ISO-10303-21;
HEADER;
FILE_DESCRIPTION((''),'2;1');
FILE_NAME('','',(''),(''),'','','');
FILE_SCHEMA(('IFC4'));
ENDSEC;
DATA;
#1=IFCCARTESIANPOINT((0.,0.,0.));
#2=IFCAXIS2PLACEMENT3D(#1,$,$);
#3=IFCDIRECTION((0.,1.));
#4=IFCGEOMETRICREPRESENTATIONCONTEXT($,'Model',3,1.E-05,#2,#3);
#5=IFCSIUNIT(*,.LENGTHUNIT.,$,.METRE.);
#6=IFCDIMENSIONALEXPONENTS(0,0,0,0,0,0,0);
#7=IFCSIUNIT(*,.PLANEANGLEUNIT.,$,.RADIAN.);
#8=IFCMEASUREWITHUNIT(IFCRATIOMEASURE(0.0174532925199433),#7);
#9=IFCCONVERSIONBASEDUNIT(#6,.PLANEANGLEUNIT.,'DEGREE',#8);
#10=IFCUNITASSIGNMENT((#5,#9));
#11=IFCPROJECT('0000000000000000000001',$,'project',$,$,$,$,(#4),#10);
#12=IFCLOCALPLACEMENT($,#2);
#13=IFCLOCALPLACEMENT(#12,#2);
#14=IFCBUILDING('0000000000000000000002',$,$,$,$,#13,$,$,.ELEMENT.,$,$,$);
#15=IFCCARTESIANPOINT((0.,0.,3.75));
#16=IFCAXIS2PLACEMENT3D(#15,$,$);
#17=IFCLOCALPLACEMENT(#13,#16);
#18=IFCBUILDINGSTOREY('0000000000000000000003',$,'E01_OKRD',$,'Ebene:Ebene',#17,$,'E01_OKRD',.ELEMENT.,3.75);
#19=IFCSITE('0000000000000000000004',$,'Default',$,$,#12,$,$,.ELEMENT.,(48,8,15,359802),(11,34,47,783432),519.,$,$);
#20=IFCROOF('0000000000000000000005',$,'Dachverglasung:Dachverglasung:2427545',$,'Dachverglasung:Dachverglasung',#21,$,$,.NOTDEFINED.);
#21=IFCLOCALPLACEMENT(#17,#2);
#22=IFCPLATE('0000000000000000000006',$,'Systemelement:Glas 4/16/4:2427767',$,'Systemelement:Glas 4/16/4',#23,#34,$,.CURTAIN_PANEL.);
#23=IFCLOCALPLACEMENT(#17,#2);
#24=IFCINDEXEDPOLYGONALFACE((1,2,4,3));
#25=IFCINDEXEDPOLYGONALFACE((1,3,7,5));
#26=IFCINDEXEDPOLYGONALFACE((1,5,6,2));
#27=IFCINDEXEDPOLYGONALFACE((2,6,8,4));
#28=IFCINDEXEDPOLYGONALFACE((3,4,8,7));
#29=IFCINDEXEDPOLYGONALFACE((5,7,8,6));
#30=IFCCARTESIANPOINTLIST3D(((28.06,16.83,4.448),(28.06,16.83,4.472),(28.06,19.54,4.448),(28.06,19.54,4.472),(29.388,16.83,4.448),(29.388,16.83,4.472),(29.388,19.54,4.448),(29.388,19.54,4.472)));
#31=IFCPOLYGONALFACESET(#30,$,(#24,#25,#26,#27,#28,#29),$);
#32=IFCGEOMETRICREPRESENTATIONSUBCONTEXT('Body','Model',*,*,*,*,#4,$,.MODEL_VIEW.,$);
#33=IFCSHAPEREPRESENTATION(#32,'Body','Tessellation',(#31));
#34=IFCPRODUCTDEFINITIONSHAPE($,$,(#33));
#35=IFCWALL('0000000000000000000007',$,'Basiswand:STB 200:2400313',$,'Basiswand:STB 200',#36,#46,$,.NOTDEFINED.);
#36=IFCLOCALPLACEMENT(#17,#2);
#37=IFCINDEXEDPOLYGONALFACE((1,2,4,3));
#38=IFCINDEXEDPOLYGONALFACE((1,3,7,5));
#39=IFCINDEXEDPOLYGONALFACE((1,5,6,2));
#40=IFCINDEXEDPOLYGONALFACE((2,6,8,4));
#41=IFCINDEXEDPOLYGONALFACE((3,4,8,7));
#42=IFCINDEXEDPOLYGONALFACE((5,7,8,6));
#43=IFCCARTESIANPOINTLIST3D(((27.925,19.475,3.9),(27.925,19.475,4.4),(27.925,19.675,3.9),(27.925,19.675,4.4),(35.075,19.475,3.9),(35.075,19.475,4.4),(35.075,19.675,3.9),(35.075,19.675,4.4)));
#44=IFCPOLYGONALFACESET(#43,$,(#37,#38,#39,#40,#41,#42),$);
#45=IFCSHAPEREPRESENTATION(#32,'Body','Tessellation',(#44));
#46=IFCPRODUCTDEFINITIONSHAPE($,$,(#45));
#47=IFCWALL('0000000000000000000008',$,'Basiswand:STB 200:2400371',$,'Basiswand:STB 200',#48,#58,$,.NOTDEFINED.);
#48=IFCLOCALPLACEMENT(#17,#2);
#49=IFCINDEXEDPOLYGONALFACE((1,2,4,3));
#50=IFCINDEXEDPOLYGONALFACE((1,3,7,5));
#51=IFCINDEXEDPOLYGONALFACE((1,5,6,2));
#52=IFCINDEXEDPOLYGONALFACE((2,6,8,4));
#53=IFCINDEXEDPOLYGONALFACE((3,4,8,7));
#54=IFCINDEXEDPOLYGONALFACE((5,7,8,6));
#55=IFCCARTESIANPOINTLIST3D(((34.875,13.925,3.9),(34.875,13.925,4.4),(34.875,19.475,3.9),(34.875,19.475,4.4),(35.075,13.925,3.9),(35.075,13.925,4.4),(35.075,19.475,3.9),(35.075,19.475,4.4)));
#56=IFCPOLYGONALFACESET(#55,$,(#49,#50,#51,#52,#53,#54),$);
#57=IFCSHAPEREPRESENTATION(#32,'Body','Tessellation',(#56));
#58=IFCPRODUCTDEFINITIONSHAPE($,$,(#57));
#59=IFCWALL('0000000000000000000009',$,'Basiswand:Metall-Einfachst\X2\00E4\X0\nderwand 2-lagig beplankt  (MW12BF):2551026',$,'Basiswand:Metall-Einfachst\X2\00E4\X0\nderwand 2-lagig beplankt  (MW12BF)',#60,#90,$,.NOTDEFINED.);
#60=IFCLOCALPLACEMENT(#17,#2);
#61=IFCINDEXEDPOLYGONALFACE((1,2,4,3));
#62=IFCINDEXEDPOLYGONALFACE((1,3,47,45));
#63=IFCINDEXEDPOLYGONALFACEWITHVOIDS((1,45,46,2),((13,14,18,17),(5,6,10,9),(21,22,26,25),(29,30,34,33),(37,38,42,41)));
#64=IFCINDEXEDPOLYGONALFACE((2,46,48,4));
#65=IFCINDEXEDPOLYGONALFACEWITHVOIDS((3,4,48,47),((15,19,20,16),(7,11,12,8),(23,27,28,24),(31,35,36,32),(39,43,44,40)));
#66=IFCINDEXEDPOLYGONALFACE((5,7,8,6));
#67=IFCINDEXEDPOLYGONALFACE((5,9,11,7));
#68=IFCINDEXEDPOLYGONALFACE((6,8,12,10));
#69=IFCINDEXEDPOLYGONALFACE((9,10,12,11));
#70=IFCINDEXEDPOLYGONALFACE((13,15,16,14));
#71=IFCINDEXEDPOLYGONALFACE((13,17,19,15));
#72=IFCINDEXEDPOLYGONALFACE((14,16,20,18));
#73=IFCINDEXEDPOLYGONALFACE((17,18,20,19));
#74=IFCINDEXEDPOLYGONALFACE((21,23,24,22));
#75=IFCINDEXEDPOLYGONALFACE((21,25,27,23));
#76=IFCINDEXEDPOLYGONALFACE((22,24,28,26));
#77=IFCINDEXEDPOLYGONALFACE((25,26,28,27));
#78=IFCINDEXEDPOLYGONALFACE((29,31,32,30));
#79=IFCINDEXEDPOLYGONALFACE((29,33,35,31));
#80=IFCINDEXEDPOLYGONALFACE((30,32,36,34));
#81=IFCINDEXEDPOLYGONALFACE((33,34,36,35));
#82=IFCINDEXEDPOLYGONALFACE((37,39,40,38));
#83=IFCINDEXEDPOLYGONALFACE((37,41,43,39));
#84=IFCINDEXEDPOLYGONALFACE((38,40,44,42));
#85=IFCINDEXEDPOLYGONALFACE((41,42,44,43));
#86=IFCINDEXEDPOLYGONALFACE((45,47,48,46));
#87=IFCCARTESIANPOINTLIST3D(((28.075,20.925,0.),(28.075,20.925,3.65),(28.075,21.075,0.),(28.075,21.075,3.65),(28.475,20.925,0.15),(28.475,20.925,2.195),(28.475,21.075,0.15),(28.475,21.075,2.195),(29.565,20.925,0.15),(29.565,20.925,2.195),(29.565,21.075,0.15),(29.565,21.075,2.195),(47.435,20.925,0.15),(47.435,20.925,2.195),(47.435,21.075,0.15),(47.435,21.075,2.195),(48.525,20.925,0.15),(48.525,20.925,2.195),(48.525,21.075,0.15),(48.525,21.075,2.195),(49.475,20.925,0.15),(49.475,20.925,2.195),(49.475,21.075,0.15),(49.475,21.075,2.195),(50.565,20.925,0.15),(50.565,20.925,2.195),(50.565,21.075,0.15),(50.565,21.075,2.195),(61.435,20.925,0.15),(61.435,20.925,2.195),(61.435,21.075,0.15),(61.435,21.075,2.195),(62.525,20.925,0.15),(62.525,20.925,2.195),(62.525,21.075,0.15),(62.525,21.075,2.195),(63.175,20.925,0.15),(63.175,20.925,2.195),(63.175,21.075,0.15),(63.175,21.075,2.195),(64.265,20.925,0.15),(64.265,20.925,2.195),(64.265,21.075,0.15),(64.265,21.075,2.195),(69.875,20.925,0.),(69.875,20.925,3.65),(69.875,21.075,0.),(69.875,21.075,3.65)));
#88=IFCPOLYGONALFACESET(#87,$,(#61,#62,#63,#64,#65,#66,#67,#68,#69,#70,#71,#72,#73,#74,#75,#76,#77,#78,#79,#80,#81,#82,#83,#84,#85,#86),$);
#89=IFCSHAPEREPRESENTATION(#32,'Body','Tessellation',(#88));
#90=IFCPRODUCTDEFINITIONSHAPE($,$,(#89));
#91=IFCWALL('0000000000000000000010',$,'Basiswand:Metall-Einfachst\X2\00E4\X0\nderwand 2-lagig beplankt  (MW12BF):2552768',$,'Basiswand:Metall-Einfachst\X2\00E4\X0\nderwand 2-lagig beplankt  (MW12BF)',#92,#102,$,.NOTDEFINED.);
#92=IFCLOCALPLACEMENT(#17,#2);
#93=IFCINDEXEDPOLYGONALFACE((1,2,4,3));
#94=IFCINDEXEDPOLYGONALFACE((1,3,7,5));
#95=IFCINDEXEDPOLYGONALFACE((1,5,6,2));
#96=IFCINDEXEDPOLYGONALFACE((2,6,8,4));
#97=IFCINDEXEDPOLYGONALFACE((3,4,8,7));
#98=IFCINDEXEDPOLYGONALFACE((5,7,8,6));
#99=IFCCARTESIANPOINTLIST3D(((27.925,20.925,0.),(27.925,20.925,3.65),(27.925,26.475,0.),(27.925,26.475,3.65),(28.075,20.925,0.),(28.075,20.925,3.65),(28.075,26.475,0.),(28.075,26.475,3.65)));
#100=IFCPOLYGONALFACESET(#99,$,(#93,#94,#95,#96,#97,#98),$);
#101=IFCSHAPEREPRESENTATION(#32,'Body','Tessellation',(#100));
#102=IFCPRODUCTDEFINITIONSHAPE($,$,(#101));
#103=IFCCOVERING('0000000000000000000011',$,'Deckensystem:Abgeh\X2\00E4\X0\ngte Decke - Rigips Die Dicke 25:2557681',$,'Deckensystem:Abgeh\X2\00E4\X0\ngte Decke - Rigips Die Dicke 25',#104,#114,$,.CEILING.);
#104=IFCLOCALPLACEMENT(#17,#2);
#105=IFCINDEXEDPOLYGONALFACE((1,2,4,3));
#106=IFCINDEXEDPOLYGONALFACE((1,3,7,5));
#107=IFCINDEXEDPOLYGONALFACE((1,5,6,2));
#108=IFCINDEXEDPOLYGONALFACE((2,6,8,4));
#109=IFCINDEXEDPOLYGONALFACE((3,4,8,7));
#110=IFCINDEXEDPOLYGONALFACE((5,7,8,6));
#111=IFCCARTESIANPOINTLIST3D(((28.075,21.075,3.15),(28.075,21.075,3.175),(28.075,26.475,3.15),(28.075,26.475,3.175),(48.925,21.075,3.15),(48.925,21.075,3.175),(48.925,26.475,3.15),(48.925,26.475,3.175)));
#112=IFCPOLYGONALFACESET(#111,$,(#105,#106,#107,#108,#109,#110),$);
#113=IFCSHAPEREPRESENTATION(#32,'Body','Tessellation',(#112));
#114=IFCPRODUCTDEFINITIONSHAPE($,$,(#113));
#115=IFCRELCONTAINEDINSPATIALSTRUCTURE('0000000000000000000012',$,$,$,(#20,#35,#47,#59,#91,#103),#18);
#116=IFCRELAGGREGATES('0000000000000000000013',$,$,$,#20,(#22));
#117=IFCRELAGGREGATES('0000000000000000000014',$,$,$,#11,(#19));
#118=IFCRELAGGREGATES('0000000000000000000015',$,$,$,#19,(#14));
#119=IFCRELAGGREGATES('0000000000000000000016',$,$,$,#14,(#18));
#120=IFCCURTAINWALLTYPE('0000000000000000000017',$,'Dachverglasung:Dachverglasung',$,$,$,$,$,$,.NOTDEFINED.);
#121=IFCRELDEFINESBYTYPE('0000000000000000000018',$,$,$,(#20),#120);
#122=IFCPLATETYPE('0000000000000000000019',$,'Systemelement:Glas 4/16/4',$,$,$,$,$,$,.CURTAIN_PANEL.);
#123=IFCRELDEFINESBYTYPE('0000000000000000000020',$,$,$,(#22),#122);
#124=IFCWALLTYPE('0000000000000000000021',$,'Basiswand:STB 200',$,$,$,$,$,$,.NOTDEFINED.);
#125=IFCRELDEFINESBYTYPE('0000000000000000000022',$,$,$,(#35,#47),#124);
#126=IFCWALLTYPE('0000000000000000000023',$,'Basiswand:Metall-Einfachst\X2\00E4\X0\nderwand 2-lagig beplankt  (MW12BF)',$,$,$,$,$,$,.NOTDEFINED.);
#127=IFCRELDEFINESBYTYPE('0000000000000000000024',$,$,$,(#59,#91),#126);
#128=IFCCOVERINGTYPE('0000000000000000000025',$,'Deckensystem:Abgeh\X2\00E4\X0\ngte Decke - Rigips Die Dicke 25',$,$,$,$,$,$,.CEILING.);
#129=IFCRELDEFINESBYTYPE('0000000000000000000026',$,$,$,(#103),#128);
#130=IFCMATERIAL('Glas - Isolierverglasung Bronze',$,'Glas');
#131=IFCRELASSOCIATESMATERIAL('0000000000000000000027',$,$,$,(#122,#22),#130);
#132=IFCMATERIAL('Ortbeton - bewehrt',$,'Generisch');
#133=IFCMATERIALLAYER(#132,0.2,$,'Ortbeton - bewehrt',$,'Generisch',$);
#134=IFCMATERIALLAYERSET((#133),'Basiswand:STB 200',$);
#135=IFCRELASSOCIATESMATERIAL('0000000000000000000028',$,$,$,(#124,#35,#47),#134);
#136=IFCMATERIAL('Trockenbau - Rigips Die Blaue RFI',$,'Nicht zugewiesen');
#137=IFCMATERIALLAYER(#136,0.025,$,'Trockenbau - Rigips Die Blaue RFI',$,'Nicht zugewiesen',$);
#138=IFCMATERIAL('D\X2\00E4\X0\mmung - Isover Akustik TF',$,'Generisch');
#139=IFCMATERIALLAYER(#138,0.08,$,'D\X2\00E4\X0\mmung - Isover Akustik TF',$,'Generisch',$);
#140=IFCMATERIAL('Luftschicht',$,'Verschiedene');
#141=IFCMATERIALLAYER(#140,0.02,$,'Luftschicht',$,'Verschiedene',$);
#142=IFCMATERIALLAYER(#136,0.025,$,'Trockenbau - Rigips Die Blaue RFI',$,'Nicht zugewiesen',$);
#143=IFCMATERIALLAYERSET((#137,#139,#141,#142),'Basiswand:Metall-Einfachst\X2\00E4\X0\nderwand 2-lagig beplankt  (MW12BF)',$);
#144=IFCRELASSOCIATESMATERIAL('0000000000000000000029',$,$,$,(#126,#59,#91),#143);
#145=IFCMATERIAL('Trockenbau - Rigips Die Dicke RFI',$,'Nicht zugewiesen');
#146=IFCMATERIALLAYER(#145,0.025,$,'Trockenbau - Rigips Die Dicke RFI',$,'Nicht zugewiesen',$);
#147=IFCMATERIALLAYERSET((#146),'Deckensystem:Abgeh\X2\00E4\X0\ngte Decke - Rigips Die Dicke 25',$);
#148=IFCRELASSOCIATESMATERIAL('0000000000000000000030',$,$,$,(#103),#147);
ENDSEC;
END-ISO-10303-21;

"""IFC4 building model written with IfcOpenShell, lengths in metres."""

from ifc_helpers import new_model, entity, si_unit, converted_unit, direction, frame, frame_2d, origin, origin_2d_with_axis, place, context, subcontext, project, spatial, rectangle, extrude, shape, source, transform, mapped, material, layer, layer_set, layer_usage, type_object, type_shapes, element, aggregate, save


model = new_model("IFC4")

# Units and contexts
model_context = context("Model", 3, precision=1e-05, world=origin(), true_north=direction((0.0, 1.0)))
body_context = subcontext(model_context, "Body", "Model", "MODEL_VIEW")
footprint_context = subcontext(model_context, "FootPrint", "Model", "MODEL_VIEW")
ifc_project = project(units=[si_unit("LENGTHUNIT", "METRE"), converted_unit("PLANEANGLEUNIT", "DEGREE", entity("IfcRatioMeasure", 0.0174532925199433), si_unit("PLANEANGLEUNIT", "RADIAN"), dimensions=[0, 0, 0, 0, 0, 0, 0])], contexts=[model_context])

# Site, building, storey
site_placement = place(None, frame((0.0, 0.0, 0.0)))
site = spatial("IfcSite", under=ifc_project, at=site_placement, Name="Default", CompositionType="ELEMENT", RefLatitude=(48, 8, 15, 359802), RefLongitude=(11, 34, 47, 783432), RefElevation=519.0)
building_placement = place(site_placement, origin())
building = spatial("IfcBuilding", under=site, at=building_placement, CompositionType="ELEMENT")
storey_placement = place(building_placement, frame((0.0, 0.0, 3.75)))
storey = spatial("IfcBuildingStorey", under=building, at=storey_placement, Name="E01_OKRD", ObjectType="Ebene:Ebene", LongName="E01_OKRD", CompositionType="ELEMENT", Elevation=3.75)

# Shared definitions
ifc_material_1 = material(Name="Ortbeton - bewehrt", Category="Generisch")

# Roof, plate
curtain_wall_type = type_object("IfcCurtainWallType", Name="Dachverglasung:Dachverglasung", PredefinedType="NOTDEFINED")
roof_placement = place(storey_placement, frame((0.0, 0.0, -3.75)))
roof = element("IfcRoof", 1, at=roof_placement, inside=storey, type_object=curtain_wall_type, Name="Dachverglasung:Dachverglasung:2427545", ObjectType="Dachverglasung:Dachverglasung", PredefinedType="NOTDEFINED")
ifc_material_2 = material(Name="Glas - Isolierverglasung Bronze", Category="Glas")
plate_type = type_object("IfcPlateType", Name="Systemelement:Glas 4/16/4", PredefinedType="CURTAIN_PANEL", material=ifc_material_2)
shared_shape_1 = source(origin(), body_context, "Body", "SweptSolid", [
    extrude(rectangle(XDim=0.024, YDim=2.71, at=origin_2d_with_axis()), frame((0.0, 0.0, 0.0), z_axis=(0.0, 0.0, 1.0), x_axis=(0.0, 1.0, 0.0)), (0.0, 0.0, 1.0), 1.328),
])
cartesian_point = entity("IfcCartesianPoint", [1.355, -0.012])
shared_shape_2 = source(origin(), footprint_context, "FootPrint", "Curve2D", [
    entity("IfcPolyline", [cartesian_point, entity("IfcCartesianPoint", [1.355, 0.012]), entity("IfcCartesianPoint", [-1.355, 0.012]), entity("IfcCartesianPoint", [-1.355, -0.012]), cartesian_point]),
])
type_shapes(plate_type, [shared_shape_1, shared_shape_2])
plate_1_placement = place(roof_placement, frame((29.388, 18.185, 8.21), z_axis=(-1.0, 0.0, 0.0), x_axis=(0.0, 1.0, 0.0)))
plate_1 = element("IfcPlate", 2, at=plate_1_placement, type_object=plate_type, material=ifc_material_2, Name="Systemelement:Glas 4/16/4:2427767", ObjectType="Systemelement:Glas 4/16/4", PredefinedType="CURTAIN_PANEL", shapes=[
    shape(body_context, "Body", "MappedRepresentation", [mapped(shared_shape_1, transform((0.0, 0.0, 0.0), scale=1.0))]),
    shape(body_context, "Body", "MappedRepresentation", [mapped(shared_shape_2, transform((0.0, 0.0, 0.0), scale=1.0))]),
])
aggregate(roof, [plate_1])

# Walls
ifc_layer_1 = layer(ifc_material_1, 0.2, Name="Ortbeton - bewehrt", Category="Generisch")
ifc_layer_set_1 = layer_set([ifc_layer_1], Name="Basiswand:STB 200")
ifc_layer_usage_1 = layer_usage(ifc_layer_set_1, "AXIS2", "NEGATIVE", 0.1)
wall_type_1 = type_object("IfcWallType", Name="Basiswand:STB 200", PredefinedType="NOTDEFINED", material=ifc_layer_set_1)
wall_1_placement = place(storey_placement, frame((27.925, 19.575, 3.9)))
element("IfcWall", 3, at=wall_1_placement, inside=storey, type_object=wall_type_1, material=ifc_layer_usage_1, Name="Basiswand:STB 200:2400313", ObjectType="Basiswand:STB 200", PredefinedType="NOTDEFINED", context=body_context, shape_type="SweptSolid", body=[
    extrude(rectangle(XDim=7.15, YDim=0.2, at=frame_2d((3.575, 0.0), x_axis=(-1.0, 0.0))), origin(), (0.0, 0.0, 1.0), 0.5),
])
ifc_layer_usage_2 = layer_usage(ifc_layer_set_1, "AXIS2", "NEGATIVE", 0.1)
wall_2_placement = place(storey_placement, frame((34.975, 19.475, 3.9), z_axis=(0.0, 0.0, 1.0), x_axis=(0.0, -1.0, 0.0)))
element("IfcWall", 4, at=wall_2_placement, inside=storey, type_object=wall_type_1, material=ifc_layer_usage_2, Name="Basiswand:STB 200:2400371", ObjectType="Basiswand:STB 200", PredefinedType="NOTDEFINED", context=body_context, shape_type="SweptSolid", body=[
    extrude(rectangle(XDim=5.55, YDim=0.2, at=frame_2d((2.775, 0.0), x_axis=(-1.0, 0.0))), origin(), (0.0, 0.0, 1.0), 0.5),
])

# Wall, openings
ifc_material_3 = material(Name="Trockenbau - Rigips Die Blaue RFI", Category="Nicht zugewiesen")
ifc_layer_2 = layer(ifc_material_3, 0.025, Name="Trockenbau - Rigips Die Blaue RFI", Category="Nicht zugewiesen")
ifc_material_4 = material(Name="Dämmung - Isover Akustik TF", Category="Generisch")
ifc_layer_3 = layer(ifc_material_4, 0.08, Name="Dämmung - Isover Akustik TF", Category="Generisch")
ifc_material_5 = material(Name="Luftschicht", Category="Verschiedene")
ifc_layer_4 = layer(ifc_material_5, 0.02, Name="Luftschicht", Category="Verschiedene")
ifc_layer_5 = layer(ifc_material_3, 0.025, Name="Trockenbau - Rigips Die Blaue RFI", Category="Nicht zugewiesen")
ifc_layer_set_2 = layer_set([ifc_layer_2, ifc_layer_3, ifc_layer_4, ifc_layer_5], Name="Basiswand:Metall-Einfachständerwand 2-lagig beplankt  (MW12BF)")
ifc_layer_usage_3 = layer_usage(ifc_layer_set_2, "AXIS2", "NEGATIVE", 0.075)
wall_type_2 = type_object("IfcWallType", Name="Basiswand:Metall-Einfachständerwand 2-lagig beplankt  (MW12BF)", PredefinedType="NOTDEFINED", material=ifc_layer_set_2)
wall_3_placement = place(storey_placement, frame((28.075, 21.0, 0.0)))
wall_3 = element("IfcWall", 5, at=wall_3_placement, inside=storey, type_object=wall_type_2, material=ifc_layer_usage_3, Name="Basiswand:Metall-Einfachständerwand 2-lagig beplankt  (MW12BF):2551026", ObjectType="Basiswand:Metall-Einfachständerwand 2-lagig beplankt  (MW12BF)", PredefinedType="NOTDEFINED", context=body_context, shape_type="SweptSolid", body=[
    extrude(rectangle(XDim=41.8, YDim=0.15, at=frame_2d((20.9, 0.0), x_axis=(-1.0, 0.0))), origin(), (0.0, 0.0, 1.0), 3.65),
])
opening_1_placement = place(wall_3_placement, frame((0.4, -0.075, 0.15)))
element("IfcOpeningElement", 6, at=opening_1_placement, cuts=wall_3, ObjectType="Opening", PredefinedType="OPENING", context=body_context, shape_type="SweptSolid", body=[
    extrude(rectangle(XDim=2.045, YDim=1.09, at=frame_2d((1.0225, 0.545), x_axis=(-1.0, 0.0))), frame((0.0, 0.0, 0.0), z_axis=(0.0, 1.0, 0.0), x_axis=(0.0, 0.0, 1.0)), (0.0, 0.0, 1.0), 0.15),
])
opening_2_placement = place(wall_3_placement, frame((19.36, -0.075, 0.15)))
element("IfcOpeningElement", 7, at=opening_2_placement, cuts=wall_3, ObjectType="Opening", PredefinedType="OPENING", context=body_context, shape_type="SweptSolid", body=[
    extrude(rectangle(XDim=2.045, YDim=1.09, at=frame_2d((1.0225, 0.545), x_axis=(-1.0, 0.0))), frame((0.0, 0.0, 0.0), z_axis=(0.0, 1.0, 0.0), x_axis=(0.0, 0.0, 1.0)), (0.0, 0.0, 1.0), 0.15),
])
opening_3_placement = place(wall_3_placement, frame((21.4, -0.075, 0.15)))
element("IfcOpeningElement", 8, at=opening_3_placement, cuts=wall_3, ObjectType="Opening", PredefinedType="OPENING", context=body_context, shape_type="SweptSolid", body=[
    extrude(rectangle(XDim=2.045, YDim=1.09, at=frame_2d((1.0225, 0.545), x_axis=(-1.0, 0.0))), frame((0.0, 0.0, 0.0), z_axis=(0.0, 1.0, 0.0), x_axis=(0.0, 0.0, 1.0)), (0.0, 0.0, 1.0), 0.15),
])
opening_4_placement = place(wall_3_placement, frame((33.36, -0.075, 0.15)))
element("IfcOpeningElement", 9, at=opening_4_placement, cuts=wall_3, ObjectType="Opening", PredefinedType="OPENING", context=body_context, shape_type="SweptSolid", body=[
    extrude(rectangle(XDim=2.045, YDim=1.09, at=frame_2d((1.0225, 0.545), x_axis=(-1.0, 0.0))), frame((0.0, 0.0, 0.0), z_axis=(0.0, 1.0, 0.0), x_axis=(0.0, 0.0, 1.0)), (0.0, 0.0, 1.0), 0.15),
])
opening_5_placement = place(wall_3_placement, frame((35.1, -0.075, 0.15)))
element("IfcOpeningElement", 10, at=opening_5_placement, cuts=wall_3, ObjectType="Opening", PredefinedType="OPENING", context=body_context, shape_type="SweptSolid", body=[
    extrude(rectangle(XDim=2.045, YDim=1.09, at=frame_2d((1.0225, 0.545), x_axis=(-1.0, 0.0))), frame((0.0, 0.0, 0.0), z_axis=(0.0, 1.0, 0.0), x_axis=(0.0, 0.0, 1.0)), (0.0, 0.0, 1.0), 0.15),
])

# Wall
ifc_layer_usage_4 = layer_usage(ifc_layer_set_2, "AXIS2", "NEGATIVE", 0.075)
wall_4_placement = place(storey_placement, frame((28.0, 20.925, 0.0), z_axis=(0.0, 0.0, 1.0), x_axis=(0.0, 1.0, 0.0)))
element("IfcWall", 11, at=wall_4_placement, inside=storey, type_object=wall_type_2, material=ifc_layer_usage_4, Name="Basiswand:Metall-Einfachständerwand 2-lagig beplankt  (MW12BF):2552768", ObjectType="Basiswand:Metall-Einfachständerwand 2-lagig beplankt  (MW12BF)", PredefinedType="NOTDEFINED", context=body_context, shape_type="SweptSolid", body=[
    extrude(rectangle(XDim=5.55, YDim=0.15, at=frame_2d((2.775, 0.0), x_axis=(-1.0, 0.0))), origin(), (0.0, 0.0, 1.0), 3.65),
])

# Covering
ifc_material_6 = material(Name="Trockenbau - Rigips Die Dicke RFI", Category="Nicht zugewiesen")
ifc_layer_6 = layer(ifc_material_6, 0.025, Name="Trockenbau - Rigips Die Dicke RFI", Category="Nicht zugewiesen")
ifc_layer_set_3 = layer_set([ifc_layer_6], Name="Deckensystem:Abgehängte Decke - Rigips Die Dicke 25")
ifc_layer_usage_5 = layer_usage(ifc_layer_set_3, "AXIS3", "POSITIVE", 0.0)
covering_type = type_object("IfcCoveringType", Name="Deckensystem:Abgehängte Decke - Rigips Die Dicke 25", PredefinedType="CEILING")
covering_placement = place(storey_placement, frame((28.075, 21.075, 3.15)))
element("IfcCovering", 12, at=covering_placement, inside=storey, type_object=covering_type, material=ifc_layer_usage_5, Name="Deckensystem:Abgehängte Decke - Rigips Die Dicke 25:2557681", ObjectType="Deckensystem:Abgehängte Decke - Rigips Die Dicke 25", PredefinedType="CEILING", context=body_context, shape_type="SweptSolid", body=[
    extrude(rectangle(XDim=20.85, YDim=5.4, at=frame_2d((0.0, 0.0), x_axis=(1.0, 0.0))), frame((10.425, 2.7, 0.0), z_axis=(0.0, 0.0, 1.0), x_axis=(-1.0, 0.0, 0.0)), (0.0, 0.0, 1.0), 0.025),
])

save(model, "model.ifc")
